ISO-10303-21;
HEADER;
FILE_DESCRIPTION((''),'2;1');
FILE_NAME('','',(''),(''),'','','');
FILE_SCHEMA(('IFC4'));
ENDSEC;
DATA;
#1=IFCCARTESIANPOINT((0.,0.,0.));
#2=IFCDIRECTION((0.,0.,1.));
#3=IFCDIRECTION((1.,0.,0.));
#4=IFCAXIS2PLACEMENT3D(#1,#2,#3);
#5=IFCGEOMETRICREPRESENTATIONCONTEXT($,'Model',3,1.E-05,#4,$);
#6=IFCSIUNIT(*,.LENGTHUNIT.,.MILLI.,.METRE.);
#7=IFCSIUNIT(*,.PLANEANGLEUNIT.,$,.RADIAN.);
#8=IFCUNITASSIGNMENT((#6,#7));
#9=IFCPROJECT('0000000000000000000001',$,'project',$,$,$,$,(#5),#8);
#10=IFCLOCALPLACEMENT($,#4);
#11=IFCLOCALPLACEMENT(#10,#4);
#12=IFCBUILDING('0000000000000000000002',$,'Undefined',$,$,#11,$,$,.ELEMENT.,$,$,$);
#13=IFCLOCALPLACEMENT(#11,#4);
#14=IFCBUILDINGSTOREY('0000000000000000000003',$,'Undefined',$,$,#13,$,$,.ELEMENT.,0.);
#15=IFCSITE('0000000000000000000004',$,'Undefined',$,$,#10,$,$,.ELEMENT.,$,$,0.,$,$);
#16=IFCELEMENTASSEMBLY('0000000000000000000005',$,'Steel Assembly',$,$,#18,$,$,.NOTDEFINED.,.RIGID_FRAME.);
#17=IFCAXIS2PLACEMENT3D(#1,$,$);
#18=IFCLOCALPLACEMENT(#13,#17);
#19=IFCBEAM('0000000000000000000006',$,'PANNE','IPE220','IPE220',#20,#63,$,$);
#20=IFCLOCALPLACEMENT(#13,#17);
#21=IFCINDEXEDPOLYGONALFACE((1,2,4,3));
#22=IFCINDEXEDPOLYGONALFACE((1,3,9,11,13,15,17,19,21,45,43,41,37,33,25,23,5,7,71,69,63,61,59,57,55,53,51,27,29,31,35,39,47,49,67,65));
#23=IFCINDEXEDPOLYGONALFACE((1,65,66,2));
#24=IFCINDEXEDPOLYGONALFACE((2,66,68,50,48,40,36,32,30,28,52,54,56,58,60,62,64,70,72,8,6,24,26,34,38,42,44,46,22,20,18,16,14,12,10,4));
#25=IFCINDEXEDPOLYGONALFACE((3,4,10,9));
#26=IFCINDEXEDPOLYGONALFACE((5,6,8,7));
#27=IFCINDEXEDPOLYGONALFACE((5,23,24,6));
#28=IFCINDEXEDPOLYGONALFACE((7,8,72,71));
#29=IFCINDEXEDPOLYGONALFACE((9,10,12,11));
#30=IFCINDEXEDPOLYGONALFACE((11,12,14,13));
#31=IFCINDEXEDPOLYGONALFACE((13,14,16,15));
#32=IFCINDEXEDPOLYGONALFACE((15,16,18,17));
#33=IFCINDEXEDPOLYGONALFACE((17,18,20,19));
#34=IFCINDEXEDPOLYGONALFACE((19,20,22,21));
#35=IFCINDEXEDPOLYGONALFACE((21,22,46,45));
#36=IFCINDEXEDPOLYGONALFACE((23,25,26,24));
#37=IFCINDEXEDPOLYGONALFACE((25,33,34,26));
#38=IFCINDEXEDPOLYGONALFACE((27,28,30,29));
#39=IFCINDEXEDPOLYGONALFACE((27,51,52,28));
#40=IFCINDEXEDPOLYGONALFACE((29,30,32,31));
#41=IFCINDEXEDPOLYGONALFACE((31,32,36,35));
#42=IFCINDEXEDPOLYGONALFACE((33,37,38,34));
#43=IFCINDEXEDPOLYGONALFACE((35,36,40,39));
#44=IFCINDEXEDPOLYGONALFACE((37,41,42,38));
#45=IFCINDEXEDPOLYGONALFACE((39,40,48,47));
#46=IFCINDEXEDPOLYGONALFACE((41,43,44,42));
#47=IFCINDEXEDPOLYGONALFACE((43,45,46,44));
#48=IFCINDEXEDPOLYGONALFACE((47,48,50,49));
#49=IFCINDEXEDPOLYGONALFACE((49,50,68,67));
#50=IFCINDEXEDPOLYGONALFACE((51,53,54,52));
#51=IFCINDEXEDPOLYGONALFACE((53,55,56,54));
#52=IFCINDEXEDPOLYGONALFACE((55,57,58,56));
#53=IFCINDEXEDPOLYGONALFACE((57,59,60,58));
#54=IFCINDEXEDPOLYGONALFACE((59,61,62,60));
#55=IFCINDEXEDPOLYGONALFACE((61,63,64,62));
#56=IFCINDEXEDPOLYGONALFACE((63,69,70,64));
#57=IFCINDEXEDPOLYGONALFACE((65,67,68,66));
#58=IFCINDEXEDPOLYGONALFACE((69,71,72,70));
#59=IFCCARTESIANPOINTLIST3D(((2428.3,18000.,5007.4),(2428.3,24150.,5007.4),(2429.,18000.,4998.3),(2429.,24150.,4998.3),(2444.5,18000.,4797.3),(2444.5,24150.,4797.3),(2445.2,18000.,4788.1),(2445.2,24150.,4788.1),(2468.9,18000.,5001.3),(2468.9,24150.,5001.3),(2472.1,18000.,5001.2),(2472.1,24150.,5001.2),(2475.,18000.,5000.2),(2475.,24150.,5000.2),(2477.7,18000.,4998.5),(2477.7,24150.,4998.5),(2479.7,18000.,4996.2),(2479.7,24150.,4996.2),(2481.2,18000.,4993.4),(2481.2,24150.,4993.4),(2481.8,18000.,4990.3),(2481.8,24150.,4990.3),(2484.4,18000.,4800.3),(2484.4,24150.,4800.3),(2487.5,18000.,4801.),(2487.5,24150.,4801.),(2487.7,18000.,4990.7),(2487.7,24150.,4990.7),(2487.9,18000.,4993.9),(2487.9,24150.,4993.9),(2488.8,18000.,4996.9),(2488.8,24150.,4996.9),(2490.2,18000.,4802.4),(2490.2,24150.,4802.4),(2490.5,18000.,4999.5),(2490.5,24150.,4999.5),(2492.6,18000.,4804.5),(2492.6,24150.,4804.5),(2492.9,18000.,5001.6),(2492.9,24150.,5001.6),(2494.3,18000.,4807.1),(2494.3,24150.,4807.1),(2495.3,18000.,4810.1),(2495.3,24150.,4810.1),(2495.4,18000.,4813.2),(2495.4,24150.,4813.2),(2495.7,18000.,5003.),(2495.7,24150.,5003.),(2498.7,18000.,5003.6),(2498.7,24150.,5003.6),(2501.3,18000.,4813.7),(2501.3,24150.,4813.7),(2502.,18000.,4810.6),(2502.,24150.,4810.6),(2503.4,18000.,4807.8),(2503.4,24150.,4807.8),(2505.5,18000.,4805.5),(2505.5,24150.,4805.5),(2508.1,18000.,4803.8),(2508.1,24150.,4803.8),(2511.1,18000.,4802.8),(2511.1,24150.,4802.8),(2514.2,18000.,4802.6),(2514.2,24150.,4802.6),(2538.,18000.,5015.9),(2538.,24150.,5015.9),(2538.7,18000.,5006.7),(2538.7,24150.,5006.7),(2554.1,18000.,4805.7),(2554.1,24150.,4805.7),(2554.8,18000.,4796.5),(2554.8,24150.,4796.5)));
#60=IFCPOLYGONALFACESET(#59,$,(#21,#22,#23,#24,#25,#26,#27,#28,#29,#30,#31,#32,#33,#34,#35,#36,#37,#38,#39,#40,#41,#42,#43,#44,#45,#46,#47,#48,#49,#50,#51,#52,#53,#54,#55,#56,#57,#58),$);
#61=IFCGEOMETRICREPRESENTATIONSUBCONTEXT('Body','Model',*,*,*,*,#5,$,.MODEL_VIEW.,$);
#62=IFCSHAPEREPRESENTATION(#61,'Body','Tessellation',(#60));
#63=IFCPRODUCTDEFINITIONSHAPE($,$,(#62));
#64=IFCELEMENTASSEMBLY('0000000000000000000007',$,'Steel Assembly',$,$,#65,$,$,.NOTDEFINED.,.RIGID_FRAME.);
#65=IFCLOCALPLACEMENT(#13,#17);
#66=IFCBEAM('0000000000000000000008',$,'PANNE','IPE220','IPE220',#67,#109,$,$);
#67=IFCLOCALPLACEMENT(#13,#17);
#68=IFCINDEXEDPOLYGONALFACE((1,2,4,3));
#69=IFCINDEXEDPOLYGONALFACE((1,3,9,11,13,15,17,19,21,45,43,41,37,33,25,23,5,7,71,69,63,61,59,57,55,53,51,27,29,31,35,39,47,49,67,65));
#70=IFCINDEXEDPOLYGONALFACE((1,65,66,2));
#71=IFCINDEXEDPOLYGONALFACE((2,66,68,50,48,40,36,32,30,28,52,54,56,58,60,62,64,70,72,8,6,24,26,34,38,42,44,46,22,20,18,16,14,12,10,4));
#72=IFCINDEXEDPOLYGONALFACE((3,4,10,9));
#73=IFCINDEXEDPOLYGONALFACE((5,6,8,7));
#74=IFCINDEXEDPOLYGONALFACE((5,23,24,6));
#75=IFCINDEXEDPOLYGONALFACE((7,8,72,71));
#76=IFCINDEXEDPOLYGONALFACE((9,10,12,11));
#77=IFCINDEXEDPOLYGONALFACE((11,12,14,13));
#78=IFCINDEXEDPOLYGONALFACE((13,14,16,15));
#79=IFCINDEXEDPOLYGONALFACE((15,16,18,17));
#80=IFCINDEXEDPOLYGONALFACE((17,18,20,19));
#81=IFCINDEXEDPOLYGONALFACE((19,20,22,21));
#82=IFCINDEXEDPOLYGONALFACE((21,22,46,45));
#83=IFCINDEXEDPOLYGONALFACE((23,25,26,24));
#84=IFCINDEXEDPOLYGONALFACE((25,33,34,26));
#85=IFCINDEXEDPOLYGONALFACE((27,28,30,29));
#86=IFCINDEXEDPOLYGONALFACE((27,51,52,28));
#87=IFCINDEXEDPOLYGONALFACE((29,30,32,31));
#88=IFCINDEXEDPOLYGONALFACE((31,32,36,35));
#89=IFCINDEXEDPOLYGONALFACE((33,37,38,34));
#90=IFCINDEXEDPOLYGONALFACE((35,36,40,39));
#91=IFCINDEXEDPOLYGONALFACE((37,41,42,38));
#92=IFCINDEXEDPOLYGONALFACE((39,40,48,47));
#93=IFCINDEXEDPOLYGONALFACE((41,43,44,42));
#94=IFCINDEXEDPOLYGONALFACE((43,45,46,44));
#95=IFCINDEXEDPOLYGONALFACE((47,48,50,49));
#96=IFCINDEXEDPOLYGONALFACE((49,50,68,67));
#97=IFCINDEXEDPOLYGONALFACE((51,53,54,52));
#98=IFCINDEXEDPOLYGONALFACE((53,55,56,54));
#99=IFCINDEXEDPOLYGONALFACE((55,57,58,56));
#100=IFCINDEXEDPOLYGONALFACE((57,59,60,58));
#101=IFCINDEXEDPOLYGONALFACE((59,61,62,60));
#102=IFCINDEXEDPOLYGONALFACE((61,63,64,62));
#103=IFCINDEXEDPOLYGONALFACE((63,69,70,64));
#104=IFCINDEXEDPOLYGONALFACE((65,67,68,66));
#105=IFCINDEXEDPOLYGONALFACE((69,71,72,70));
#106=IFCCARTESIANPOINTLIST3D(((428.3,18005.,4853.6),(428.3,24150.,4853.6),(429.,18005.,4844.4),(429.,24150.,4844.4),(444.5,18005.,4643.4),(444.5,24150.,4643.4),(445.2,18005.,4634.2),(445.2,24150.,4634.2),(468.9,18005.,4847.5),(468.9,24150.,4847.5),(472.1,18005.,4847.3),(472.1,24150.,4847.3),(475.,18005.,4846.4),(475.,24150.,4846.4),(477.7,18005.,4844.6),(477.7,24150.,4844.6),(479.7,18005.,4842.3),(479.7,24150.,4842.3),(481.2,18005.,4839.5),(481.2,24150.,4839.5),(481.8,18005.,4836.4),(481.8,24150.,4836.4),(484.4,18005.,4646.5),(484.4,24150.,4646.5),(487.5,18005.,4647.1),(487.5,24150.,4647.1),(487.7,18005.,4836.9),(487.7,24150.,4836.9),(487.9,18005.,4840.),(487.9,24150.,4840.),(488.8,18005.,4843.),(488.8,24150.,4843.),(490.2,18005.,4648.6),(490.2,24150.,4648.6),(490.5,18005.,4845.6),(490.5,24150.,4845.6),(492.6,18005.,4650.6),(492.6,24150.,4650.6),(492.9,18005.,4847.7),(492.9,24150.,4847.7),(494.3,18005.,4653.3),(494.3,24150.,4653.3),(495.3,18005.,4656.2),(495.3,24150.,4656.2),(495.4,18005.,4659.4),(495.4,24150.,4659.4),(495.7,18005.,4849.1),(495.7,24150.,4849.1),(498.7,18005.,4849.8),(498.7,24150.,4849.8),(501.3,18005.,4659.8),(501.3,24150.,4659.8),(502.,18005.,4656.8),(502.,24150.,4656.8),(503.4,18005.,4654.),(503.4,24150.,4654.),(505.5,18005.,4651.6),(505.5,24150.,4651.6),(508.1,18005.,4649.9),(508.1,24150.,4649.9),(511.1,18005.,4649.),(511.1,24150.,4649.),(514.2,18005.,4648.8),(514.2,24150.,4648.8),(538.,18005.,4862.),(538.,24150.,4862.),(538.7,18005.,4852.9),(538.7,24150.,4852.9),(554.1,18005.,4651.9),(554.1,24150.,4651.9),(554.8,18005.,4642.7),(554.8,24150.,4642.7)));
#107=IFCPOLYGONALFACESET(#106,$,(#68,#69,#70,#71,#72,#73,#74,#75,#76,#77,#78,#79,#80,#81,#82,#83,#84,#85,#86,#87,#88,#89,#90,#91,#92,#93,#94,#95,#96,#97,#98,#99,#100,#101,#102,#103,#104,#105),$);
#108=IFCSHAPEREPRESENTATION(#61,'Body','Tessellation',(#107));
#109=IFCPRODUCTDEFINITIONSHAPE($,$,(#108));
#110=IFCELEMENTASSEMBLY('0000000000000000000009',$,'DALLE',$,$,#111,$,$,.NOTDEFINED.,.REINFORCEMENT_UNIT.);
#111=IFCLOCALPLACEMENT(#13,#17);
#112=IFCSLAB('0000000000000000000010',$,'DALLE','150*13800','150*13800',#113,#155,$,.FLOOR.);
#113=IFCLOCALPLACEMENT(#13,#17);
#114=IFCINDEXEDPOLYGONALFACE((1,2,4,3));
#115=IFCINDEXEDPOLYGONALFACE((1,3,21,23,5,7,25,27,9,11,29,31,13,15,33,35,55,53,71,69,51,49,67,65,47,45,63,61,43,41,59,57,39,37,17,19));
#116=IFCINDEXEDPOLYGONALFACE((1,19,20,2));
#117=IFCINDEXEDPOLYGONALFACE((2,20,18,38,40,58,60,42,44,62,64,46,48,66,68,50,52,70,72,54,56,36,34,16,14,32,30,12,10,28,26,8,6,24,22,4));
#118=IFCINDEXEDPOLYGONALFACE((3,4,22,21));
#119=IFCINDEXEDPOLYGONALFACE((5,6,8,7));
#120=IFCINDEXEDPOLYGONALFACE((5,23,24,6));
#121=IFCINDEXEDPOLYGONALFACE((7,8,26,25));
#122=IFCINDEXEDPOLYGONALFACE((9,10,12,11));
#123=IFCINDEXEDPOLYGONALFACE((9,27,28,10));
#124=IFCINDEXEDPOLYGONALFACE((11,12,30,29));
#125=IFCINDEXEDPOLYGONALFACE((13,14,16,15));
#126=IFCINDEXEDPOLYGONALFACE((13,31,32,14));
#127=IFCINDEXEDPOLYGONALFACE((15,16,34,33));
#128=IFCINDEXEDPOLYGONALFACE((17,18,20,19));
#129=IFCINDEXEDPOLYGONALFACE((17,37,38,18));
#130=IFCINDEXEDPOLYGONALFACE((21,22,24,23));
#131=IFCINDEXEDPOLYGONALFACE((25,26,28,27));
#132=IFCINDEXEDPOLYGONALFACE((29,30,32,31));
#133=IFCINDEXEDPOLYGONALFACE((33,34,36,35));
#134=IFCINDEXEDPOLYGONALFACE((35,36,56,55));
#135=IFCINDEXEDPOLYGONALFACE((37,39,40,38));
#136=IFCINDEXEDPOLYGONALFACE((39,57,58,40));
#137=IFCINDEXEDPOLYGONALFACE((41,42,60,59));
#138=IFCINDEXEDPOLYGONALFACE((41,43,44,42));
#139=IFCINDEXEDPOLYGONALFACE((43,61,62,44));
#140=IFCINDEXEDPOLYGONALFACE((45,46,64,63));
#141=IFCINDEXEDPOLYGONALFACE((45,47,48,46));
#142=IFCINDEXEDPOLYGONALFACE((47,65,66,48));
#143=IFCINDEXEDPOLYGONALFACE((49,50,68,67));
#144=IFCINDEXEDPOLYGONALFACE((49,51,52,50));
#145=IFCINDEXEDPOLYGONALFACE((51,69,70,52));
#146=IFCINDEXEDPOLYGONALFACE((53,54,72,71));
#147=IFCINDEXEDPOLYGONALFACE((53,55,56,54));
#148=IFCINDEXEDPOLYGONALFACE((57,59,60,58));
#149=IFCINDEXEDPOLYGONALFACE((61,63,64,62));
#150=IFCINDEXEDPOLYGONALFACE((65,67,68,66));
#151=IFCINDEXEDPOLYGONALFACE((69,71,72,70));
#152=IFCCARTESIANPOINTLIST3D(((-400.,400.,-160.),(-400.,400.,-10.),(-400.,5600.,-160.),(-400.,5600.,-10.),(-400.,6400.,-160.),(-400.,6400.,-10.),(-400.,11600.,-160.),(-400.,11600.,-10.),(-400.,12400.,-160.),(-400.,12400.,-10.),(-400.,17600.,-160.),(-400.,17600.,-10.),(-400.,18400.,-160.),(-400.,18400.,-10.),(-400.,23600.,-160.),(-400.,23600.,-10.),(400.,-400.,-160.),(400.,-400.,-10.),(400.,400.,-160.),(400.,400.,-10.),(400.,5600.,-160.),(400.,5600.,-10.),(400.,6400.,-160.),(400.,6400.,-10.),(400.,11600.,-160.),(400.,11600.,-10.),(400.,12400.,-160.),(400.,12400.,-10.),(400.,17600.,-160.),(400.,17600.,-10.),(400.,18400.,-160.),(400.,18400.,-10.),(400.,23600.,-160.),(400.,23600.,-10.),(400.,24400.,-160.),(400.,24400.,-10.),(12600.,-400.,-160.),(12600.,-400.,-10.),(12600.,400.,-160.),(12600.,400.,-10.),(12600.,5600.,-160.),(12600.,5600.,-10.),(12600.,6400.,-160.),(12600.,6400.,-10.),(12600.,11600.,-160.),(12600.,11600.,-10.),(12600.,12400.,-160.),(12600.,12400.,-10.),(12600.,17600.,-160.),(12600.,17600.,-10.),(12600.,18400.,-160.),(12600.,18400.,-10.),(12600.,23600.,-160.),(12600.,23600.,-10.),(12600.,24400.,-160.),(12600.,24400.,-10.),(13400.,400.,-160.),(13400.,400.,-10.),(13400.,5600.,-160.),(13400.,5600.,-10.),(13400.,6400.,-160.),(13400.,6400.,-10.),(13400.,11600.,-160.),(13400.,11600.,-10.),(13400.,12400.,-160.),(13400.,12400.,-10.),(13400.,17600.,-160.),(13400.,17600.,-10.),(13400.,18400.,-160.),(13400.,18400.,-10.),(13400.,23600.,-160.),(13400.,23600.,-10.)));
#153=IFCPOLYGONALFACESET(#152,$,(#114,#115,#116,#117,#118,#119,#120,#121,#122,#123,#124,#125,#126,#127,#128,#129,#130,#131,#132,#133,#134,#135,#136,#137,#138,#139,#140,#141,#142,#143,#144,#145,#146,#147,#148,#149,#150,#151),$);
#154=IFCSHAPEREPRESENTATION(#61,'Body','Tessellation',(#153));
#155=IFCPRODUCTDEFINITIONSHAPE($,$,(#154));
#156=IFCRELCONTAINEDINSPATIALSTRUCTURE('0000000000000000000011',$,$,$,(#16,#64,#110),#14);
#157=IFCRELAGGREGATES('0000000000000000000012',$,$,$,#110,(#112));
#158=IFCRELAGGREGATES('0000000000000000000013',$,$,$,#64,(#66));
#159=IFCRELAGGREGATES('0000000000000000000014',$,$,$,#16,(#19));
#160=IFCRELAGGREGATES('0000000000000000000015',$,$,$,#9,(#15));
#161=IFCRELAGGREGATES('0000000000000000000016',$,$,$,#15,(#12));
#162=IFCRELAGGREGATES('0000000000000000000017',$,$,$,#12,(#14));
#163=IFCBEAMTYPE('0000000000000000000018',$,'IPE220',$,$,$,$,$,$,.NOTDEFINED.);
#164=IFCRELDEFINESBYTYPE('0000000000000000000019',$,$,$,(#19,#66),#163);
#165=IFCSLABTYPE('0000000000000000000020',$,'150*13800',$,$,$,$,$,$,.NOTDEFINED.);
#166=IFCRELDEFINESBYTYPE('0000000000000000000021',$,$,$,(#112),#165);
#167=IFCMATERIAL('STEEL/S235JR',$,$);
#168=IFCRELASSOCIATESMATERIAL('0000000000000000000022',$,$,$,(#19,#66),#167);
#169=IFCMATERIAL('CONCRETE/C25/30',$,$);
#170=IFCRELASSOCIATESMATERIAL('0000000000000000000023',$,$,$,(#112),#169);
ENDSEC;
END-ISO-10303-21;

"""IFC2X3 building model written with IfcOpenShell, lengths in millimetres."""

from ifc_helpers import new_model, si_unit, frame, origin_with_axes, origin_2d_with_axis, place, context, subcontext, project, spatial, polyline, rectangle, i_section, outline, extrude, boolean, clip, halfspace, material, type_object, element, aggregate, save


model = new_model("IFC2X3")

# Units and contexts
model_context = context("Model", 3, precision=1e-05, world=origin_with_axes())
body_context = subcontext(model_context, "Body", "Model", "MODEL_VIEW")
ifc_project = project(units=[si_unit("LENGTHUNIT", "METRE", prefix="MILLI"), si_unit("PLANEANGLEUNIT", "RADIAN")], contexts=[model_context])

# Site, building, storey
site_placement = place(None, origin_with_axes())
site = spatial("IfcSite", under=ifc_project, at=site_placement, Name="Undefined", CompositionType="ELEMENT", RefElevation=0.0)
building_placement = place(site_placement, origin_with_axes())
building = spatial("IfcBuilding", under=site, at=building_placement, Name="Undefined", CompositionType="ELEMENT")
storey_placement = place(building_placement, origin_with_axes())
storey = spatial("IfcBuildingStorey", under=building, at=storey_placement, Name="Undefined", CompositionType="ELEMENT", Elevation=0.0)

# Element assemblies, beams
ifc_material_1 = material(Name="STEEL/S235JR")
assembly_1_placement = place(storey_placement, origin_with_axes())
assembly_1 = element("IfcElementAssembly", 1, at=assembly_1_placement, inside=storey, Name="Steel Assembly", AssemblyPlace="NOTDEFINED", PredefinedType="RIGID_FRAME")
beam_type_1 = type_object("IfcBeamType", Name="IPE220", PredefinedType="NOTDEFINED")
beam_1_placement = place(assembly_1_placement, frame((2491.6, 24150.0, 4902.0), z_axis=(-0.076696, 0.0, 0.997054), x_axis=(0.0, -1.0, 0.0)))
beam_1 = element("IfcBeam", 2, at=beam_1_placement, type_object=beam_type_1, material=ifc_material_1, Name="PANNE", Description="IPE220", ObjectType="IPE220", context=body_context, shape_type="SweptSolid", body=[
    extrude(i_section(OverallWidth=110.0, OverallDepth=220.0, WebThickness=5.9, FlangeThickness=9.2, FilletRadius=12.0, at=origin_2d_with_axis()), frame((6150.0, 0.0, 0.0), z_axis=(-1.0, 0.0, 0.0), x_axis=(0.0, -1.0, 0.0)), (0.0, 0.0, 1.0), 6150.0),
])
assembly_2_placement = place(storey_placement, origin_with_axes())
assembly_2 = element("IfcElementAssembly", 3, at=assembly_2_placement, inside=storey, Name="Steel Assembly", AssemblyPlace="NOTDEFINED", PredefinedType="RIGID_FRAME")
beam_2_placement = place(assembly_2_placement, frame((491.6, 24150.0, 4748.1), z_axis=(-0.076696, 0.0, 0.997054), x_axis=(0.0, -1.0, 0.0)))
beam_2 = element("IfcBeam", 4, at=beam_2_placement, type_object=beam_type_1, material=ifc_material_1, Name="PANNE", Description="IPE220", ObjectType="IPE220", context=body_context, shape_type="Clipping", body=[
    clip(extrude(i_section(OverallWidth=110.0, OverallDepth=220.0, WebThickness=5.9, FlangeThickness=9.2, FilletRadius=12.0, at=origin_2d_with_axis()), frame((6145.0, 0.0, 0.0), z_axis=(-1.0, 0.0, 0.0), x_axis=(0.0, -1.0, 0.0)), (0.0, 0.0, 1.0), 6145.0), halfspace(frame((6145.0, 0.0, 0.0), z_axis=(1.0, 0.0, 0.0), x_axis=(0.0, -1.0, 0.0)), False)),
])

# Element assembly, slab
assembly_3_placement = place(storey_placement, origin_with_axes())
assembly_3 = element("IfcElementAssembly", 5, at=assembly_3_placement, inside=storey, Name="DALLE", AssemblyPlace="NOTDEFINED", PredefinedType="REINFORCEMENT_UNIT")
ifc_material_2 = material(Name="CONCRETE/C25/30")
slab_type = type_object("IfcSlabType", Name="150*13800", PredefinedType="NOTDEFINED")
slab_placement = place(assembly_3_placement, frame((-400.0, 24400.0, -85.0), z_axis=(0.0, 0.0, 1.0), x_axis=(0.0, -1.0, 0.0)))
solid = boolean("DIFFERENCE", boolean("DIFFERENCE", boolean("DIFFERENCE", boolean("DIFFERENCE", boolean("DIFFERENCE", boolean("DIFFERENCE", boolean("DIFFERENCE", boolean("DIFFERENCE", extrude(outline(polyline([(0.0, 0.0), (24800.0, 0.0), (24800.0, 13800.0), (0.0, 13800.0), (0.0, 0.0)])), frame((0.0, 0.0, -75.0), z_axis=(0.0, 0.0, 1.0), x_axis=(1.0, 0.0, 0.0)), (0.0, 0.0, 1.0), 150.0), extrude(rectangle(XDim=800.0, YDim=800.0, at=origin_2d_with_axis()), frame((400.0, 13400.0, 75.0), z_axis=(0.0, 0.0, -1.0), x_axis=(0.0, 1.0, 0.0)), (0.0, 0.0, 1.0), 500.0)), extrude(rectangle(XDim=800.0, YDim=800.0, at=origin_2d_with_axis()), frame((6400.0, 13400.0, 75.0), z_axis=(0.0, 0.0, -1.0), x_axis=(0.0, 1.0, 0.0)), (0.0, 0.0, 1.0), 500.0)), extrude(rectangle(XDim=800.0, YDim=800.0, at=origin_2d_with_axis()), frame((12400.0, 13400.0, 75.0), z_axis=(0.0, 0.0, -1.0), x_axis=(0.0, 1.0, 0.0)), (0.0, 0.0, 1.0), 500.0)), extrude(rectangle(XDim=800.0, YDim=800.0, at=origin_2d_with_axis()), frame((18400.0, 13400.0, 75.0), z_axis=(0.0, 0.0, -1.0), x_axis=(0.0, 1.0, 0.0)), (0.0, 0.0, 1.0), 500.0)), extrude(rectangle(XDim=800.0, YDim=800.0, at=origin_2d_with_axis()), frame((24400.0, 13400.0, 75.0), z_axis=(0.0, 0.0, -1.0), x_axis=(0.0, 1.0, 0.0)), (0.0, 0.0, 1.0), 500.0)), extrude(rectangle(XDim=800.0, YDim=800.0, at=origin_2d_with_axis()), frame((400.0, 400.0, 75.0), z_axis=(0.0, 0.0, -1.0), x_axis=(0.0, 1.0, 0.0)), (0.0, 0.0, 1.0), 500.0)), extrude(rectangle(XDim=800.0, YDim=800.0, at=origin_2d_with_axis()), frame((6400.0, 400.0, 75.0), z_axis=(0.0, 0.0, -1.0), x_axis=(0.0, 1.0, 0.0)), (0.0, 0.0, 1.0), 500.0)), extrude(rectangle(XDim=800.0, YDim=800.0, at=origin_2d_with_axis()), frame((12400.0, 400.0, 75.0), z_axis=(0.0, 0.0, -1.0), x_axis=(0.0, 1.0, 0.0)), (0.0, 0.0, 1.0), 500.0))
slab = element("IfcSlab", 6, at=slab_placement, type_object=slab_type, material=ifc_material_2, Name="DALLE", Description="150*13800", ObjectType="150*13800", PredefinedType="FLOOR", context=body_context, shape_type="CSG", body=[
    boolean("DIFFERENCE", boolean("DIFFERENCE", solid, extrude(rectangle(XDim=800.0, YDim=800.0, at=origin_2d_with_axis()), frame((18400.0, 400.0, 75.0), z_axis=(0.0, 0.0, -1.0), x_axis=(0.0, 1.0, 0.0)), (0.0, 0.0, 1.0), 500.0)), extrude(rectangle(XDim=800.0, YDim=800.0, at=origin_2d_with_axis()), frame((24400.0, 400.0, 75.0), z_axis=(0.0, 0.0, -1.0), x_axis=(0.0, 1.0, 0.0)), (0.0, 0.0, 1.0), 500.0)),
])
aggregate(assembly_3, [slab])

aggregate(assembly_2, [beam_2])
aggregate(assembly_1, [beam_1])

save(model, "model.ifc")
